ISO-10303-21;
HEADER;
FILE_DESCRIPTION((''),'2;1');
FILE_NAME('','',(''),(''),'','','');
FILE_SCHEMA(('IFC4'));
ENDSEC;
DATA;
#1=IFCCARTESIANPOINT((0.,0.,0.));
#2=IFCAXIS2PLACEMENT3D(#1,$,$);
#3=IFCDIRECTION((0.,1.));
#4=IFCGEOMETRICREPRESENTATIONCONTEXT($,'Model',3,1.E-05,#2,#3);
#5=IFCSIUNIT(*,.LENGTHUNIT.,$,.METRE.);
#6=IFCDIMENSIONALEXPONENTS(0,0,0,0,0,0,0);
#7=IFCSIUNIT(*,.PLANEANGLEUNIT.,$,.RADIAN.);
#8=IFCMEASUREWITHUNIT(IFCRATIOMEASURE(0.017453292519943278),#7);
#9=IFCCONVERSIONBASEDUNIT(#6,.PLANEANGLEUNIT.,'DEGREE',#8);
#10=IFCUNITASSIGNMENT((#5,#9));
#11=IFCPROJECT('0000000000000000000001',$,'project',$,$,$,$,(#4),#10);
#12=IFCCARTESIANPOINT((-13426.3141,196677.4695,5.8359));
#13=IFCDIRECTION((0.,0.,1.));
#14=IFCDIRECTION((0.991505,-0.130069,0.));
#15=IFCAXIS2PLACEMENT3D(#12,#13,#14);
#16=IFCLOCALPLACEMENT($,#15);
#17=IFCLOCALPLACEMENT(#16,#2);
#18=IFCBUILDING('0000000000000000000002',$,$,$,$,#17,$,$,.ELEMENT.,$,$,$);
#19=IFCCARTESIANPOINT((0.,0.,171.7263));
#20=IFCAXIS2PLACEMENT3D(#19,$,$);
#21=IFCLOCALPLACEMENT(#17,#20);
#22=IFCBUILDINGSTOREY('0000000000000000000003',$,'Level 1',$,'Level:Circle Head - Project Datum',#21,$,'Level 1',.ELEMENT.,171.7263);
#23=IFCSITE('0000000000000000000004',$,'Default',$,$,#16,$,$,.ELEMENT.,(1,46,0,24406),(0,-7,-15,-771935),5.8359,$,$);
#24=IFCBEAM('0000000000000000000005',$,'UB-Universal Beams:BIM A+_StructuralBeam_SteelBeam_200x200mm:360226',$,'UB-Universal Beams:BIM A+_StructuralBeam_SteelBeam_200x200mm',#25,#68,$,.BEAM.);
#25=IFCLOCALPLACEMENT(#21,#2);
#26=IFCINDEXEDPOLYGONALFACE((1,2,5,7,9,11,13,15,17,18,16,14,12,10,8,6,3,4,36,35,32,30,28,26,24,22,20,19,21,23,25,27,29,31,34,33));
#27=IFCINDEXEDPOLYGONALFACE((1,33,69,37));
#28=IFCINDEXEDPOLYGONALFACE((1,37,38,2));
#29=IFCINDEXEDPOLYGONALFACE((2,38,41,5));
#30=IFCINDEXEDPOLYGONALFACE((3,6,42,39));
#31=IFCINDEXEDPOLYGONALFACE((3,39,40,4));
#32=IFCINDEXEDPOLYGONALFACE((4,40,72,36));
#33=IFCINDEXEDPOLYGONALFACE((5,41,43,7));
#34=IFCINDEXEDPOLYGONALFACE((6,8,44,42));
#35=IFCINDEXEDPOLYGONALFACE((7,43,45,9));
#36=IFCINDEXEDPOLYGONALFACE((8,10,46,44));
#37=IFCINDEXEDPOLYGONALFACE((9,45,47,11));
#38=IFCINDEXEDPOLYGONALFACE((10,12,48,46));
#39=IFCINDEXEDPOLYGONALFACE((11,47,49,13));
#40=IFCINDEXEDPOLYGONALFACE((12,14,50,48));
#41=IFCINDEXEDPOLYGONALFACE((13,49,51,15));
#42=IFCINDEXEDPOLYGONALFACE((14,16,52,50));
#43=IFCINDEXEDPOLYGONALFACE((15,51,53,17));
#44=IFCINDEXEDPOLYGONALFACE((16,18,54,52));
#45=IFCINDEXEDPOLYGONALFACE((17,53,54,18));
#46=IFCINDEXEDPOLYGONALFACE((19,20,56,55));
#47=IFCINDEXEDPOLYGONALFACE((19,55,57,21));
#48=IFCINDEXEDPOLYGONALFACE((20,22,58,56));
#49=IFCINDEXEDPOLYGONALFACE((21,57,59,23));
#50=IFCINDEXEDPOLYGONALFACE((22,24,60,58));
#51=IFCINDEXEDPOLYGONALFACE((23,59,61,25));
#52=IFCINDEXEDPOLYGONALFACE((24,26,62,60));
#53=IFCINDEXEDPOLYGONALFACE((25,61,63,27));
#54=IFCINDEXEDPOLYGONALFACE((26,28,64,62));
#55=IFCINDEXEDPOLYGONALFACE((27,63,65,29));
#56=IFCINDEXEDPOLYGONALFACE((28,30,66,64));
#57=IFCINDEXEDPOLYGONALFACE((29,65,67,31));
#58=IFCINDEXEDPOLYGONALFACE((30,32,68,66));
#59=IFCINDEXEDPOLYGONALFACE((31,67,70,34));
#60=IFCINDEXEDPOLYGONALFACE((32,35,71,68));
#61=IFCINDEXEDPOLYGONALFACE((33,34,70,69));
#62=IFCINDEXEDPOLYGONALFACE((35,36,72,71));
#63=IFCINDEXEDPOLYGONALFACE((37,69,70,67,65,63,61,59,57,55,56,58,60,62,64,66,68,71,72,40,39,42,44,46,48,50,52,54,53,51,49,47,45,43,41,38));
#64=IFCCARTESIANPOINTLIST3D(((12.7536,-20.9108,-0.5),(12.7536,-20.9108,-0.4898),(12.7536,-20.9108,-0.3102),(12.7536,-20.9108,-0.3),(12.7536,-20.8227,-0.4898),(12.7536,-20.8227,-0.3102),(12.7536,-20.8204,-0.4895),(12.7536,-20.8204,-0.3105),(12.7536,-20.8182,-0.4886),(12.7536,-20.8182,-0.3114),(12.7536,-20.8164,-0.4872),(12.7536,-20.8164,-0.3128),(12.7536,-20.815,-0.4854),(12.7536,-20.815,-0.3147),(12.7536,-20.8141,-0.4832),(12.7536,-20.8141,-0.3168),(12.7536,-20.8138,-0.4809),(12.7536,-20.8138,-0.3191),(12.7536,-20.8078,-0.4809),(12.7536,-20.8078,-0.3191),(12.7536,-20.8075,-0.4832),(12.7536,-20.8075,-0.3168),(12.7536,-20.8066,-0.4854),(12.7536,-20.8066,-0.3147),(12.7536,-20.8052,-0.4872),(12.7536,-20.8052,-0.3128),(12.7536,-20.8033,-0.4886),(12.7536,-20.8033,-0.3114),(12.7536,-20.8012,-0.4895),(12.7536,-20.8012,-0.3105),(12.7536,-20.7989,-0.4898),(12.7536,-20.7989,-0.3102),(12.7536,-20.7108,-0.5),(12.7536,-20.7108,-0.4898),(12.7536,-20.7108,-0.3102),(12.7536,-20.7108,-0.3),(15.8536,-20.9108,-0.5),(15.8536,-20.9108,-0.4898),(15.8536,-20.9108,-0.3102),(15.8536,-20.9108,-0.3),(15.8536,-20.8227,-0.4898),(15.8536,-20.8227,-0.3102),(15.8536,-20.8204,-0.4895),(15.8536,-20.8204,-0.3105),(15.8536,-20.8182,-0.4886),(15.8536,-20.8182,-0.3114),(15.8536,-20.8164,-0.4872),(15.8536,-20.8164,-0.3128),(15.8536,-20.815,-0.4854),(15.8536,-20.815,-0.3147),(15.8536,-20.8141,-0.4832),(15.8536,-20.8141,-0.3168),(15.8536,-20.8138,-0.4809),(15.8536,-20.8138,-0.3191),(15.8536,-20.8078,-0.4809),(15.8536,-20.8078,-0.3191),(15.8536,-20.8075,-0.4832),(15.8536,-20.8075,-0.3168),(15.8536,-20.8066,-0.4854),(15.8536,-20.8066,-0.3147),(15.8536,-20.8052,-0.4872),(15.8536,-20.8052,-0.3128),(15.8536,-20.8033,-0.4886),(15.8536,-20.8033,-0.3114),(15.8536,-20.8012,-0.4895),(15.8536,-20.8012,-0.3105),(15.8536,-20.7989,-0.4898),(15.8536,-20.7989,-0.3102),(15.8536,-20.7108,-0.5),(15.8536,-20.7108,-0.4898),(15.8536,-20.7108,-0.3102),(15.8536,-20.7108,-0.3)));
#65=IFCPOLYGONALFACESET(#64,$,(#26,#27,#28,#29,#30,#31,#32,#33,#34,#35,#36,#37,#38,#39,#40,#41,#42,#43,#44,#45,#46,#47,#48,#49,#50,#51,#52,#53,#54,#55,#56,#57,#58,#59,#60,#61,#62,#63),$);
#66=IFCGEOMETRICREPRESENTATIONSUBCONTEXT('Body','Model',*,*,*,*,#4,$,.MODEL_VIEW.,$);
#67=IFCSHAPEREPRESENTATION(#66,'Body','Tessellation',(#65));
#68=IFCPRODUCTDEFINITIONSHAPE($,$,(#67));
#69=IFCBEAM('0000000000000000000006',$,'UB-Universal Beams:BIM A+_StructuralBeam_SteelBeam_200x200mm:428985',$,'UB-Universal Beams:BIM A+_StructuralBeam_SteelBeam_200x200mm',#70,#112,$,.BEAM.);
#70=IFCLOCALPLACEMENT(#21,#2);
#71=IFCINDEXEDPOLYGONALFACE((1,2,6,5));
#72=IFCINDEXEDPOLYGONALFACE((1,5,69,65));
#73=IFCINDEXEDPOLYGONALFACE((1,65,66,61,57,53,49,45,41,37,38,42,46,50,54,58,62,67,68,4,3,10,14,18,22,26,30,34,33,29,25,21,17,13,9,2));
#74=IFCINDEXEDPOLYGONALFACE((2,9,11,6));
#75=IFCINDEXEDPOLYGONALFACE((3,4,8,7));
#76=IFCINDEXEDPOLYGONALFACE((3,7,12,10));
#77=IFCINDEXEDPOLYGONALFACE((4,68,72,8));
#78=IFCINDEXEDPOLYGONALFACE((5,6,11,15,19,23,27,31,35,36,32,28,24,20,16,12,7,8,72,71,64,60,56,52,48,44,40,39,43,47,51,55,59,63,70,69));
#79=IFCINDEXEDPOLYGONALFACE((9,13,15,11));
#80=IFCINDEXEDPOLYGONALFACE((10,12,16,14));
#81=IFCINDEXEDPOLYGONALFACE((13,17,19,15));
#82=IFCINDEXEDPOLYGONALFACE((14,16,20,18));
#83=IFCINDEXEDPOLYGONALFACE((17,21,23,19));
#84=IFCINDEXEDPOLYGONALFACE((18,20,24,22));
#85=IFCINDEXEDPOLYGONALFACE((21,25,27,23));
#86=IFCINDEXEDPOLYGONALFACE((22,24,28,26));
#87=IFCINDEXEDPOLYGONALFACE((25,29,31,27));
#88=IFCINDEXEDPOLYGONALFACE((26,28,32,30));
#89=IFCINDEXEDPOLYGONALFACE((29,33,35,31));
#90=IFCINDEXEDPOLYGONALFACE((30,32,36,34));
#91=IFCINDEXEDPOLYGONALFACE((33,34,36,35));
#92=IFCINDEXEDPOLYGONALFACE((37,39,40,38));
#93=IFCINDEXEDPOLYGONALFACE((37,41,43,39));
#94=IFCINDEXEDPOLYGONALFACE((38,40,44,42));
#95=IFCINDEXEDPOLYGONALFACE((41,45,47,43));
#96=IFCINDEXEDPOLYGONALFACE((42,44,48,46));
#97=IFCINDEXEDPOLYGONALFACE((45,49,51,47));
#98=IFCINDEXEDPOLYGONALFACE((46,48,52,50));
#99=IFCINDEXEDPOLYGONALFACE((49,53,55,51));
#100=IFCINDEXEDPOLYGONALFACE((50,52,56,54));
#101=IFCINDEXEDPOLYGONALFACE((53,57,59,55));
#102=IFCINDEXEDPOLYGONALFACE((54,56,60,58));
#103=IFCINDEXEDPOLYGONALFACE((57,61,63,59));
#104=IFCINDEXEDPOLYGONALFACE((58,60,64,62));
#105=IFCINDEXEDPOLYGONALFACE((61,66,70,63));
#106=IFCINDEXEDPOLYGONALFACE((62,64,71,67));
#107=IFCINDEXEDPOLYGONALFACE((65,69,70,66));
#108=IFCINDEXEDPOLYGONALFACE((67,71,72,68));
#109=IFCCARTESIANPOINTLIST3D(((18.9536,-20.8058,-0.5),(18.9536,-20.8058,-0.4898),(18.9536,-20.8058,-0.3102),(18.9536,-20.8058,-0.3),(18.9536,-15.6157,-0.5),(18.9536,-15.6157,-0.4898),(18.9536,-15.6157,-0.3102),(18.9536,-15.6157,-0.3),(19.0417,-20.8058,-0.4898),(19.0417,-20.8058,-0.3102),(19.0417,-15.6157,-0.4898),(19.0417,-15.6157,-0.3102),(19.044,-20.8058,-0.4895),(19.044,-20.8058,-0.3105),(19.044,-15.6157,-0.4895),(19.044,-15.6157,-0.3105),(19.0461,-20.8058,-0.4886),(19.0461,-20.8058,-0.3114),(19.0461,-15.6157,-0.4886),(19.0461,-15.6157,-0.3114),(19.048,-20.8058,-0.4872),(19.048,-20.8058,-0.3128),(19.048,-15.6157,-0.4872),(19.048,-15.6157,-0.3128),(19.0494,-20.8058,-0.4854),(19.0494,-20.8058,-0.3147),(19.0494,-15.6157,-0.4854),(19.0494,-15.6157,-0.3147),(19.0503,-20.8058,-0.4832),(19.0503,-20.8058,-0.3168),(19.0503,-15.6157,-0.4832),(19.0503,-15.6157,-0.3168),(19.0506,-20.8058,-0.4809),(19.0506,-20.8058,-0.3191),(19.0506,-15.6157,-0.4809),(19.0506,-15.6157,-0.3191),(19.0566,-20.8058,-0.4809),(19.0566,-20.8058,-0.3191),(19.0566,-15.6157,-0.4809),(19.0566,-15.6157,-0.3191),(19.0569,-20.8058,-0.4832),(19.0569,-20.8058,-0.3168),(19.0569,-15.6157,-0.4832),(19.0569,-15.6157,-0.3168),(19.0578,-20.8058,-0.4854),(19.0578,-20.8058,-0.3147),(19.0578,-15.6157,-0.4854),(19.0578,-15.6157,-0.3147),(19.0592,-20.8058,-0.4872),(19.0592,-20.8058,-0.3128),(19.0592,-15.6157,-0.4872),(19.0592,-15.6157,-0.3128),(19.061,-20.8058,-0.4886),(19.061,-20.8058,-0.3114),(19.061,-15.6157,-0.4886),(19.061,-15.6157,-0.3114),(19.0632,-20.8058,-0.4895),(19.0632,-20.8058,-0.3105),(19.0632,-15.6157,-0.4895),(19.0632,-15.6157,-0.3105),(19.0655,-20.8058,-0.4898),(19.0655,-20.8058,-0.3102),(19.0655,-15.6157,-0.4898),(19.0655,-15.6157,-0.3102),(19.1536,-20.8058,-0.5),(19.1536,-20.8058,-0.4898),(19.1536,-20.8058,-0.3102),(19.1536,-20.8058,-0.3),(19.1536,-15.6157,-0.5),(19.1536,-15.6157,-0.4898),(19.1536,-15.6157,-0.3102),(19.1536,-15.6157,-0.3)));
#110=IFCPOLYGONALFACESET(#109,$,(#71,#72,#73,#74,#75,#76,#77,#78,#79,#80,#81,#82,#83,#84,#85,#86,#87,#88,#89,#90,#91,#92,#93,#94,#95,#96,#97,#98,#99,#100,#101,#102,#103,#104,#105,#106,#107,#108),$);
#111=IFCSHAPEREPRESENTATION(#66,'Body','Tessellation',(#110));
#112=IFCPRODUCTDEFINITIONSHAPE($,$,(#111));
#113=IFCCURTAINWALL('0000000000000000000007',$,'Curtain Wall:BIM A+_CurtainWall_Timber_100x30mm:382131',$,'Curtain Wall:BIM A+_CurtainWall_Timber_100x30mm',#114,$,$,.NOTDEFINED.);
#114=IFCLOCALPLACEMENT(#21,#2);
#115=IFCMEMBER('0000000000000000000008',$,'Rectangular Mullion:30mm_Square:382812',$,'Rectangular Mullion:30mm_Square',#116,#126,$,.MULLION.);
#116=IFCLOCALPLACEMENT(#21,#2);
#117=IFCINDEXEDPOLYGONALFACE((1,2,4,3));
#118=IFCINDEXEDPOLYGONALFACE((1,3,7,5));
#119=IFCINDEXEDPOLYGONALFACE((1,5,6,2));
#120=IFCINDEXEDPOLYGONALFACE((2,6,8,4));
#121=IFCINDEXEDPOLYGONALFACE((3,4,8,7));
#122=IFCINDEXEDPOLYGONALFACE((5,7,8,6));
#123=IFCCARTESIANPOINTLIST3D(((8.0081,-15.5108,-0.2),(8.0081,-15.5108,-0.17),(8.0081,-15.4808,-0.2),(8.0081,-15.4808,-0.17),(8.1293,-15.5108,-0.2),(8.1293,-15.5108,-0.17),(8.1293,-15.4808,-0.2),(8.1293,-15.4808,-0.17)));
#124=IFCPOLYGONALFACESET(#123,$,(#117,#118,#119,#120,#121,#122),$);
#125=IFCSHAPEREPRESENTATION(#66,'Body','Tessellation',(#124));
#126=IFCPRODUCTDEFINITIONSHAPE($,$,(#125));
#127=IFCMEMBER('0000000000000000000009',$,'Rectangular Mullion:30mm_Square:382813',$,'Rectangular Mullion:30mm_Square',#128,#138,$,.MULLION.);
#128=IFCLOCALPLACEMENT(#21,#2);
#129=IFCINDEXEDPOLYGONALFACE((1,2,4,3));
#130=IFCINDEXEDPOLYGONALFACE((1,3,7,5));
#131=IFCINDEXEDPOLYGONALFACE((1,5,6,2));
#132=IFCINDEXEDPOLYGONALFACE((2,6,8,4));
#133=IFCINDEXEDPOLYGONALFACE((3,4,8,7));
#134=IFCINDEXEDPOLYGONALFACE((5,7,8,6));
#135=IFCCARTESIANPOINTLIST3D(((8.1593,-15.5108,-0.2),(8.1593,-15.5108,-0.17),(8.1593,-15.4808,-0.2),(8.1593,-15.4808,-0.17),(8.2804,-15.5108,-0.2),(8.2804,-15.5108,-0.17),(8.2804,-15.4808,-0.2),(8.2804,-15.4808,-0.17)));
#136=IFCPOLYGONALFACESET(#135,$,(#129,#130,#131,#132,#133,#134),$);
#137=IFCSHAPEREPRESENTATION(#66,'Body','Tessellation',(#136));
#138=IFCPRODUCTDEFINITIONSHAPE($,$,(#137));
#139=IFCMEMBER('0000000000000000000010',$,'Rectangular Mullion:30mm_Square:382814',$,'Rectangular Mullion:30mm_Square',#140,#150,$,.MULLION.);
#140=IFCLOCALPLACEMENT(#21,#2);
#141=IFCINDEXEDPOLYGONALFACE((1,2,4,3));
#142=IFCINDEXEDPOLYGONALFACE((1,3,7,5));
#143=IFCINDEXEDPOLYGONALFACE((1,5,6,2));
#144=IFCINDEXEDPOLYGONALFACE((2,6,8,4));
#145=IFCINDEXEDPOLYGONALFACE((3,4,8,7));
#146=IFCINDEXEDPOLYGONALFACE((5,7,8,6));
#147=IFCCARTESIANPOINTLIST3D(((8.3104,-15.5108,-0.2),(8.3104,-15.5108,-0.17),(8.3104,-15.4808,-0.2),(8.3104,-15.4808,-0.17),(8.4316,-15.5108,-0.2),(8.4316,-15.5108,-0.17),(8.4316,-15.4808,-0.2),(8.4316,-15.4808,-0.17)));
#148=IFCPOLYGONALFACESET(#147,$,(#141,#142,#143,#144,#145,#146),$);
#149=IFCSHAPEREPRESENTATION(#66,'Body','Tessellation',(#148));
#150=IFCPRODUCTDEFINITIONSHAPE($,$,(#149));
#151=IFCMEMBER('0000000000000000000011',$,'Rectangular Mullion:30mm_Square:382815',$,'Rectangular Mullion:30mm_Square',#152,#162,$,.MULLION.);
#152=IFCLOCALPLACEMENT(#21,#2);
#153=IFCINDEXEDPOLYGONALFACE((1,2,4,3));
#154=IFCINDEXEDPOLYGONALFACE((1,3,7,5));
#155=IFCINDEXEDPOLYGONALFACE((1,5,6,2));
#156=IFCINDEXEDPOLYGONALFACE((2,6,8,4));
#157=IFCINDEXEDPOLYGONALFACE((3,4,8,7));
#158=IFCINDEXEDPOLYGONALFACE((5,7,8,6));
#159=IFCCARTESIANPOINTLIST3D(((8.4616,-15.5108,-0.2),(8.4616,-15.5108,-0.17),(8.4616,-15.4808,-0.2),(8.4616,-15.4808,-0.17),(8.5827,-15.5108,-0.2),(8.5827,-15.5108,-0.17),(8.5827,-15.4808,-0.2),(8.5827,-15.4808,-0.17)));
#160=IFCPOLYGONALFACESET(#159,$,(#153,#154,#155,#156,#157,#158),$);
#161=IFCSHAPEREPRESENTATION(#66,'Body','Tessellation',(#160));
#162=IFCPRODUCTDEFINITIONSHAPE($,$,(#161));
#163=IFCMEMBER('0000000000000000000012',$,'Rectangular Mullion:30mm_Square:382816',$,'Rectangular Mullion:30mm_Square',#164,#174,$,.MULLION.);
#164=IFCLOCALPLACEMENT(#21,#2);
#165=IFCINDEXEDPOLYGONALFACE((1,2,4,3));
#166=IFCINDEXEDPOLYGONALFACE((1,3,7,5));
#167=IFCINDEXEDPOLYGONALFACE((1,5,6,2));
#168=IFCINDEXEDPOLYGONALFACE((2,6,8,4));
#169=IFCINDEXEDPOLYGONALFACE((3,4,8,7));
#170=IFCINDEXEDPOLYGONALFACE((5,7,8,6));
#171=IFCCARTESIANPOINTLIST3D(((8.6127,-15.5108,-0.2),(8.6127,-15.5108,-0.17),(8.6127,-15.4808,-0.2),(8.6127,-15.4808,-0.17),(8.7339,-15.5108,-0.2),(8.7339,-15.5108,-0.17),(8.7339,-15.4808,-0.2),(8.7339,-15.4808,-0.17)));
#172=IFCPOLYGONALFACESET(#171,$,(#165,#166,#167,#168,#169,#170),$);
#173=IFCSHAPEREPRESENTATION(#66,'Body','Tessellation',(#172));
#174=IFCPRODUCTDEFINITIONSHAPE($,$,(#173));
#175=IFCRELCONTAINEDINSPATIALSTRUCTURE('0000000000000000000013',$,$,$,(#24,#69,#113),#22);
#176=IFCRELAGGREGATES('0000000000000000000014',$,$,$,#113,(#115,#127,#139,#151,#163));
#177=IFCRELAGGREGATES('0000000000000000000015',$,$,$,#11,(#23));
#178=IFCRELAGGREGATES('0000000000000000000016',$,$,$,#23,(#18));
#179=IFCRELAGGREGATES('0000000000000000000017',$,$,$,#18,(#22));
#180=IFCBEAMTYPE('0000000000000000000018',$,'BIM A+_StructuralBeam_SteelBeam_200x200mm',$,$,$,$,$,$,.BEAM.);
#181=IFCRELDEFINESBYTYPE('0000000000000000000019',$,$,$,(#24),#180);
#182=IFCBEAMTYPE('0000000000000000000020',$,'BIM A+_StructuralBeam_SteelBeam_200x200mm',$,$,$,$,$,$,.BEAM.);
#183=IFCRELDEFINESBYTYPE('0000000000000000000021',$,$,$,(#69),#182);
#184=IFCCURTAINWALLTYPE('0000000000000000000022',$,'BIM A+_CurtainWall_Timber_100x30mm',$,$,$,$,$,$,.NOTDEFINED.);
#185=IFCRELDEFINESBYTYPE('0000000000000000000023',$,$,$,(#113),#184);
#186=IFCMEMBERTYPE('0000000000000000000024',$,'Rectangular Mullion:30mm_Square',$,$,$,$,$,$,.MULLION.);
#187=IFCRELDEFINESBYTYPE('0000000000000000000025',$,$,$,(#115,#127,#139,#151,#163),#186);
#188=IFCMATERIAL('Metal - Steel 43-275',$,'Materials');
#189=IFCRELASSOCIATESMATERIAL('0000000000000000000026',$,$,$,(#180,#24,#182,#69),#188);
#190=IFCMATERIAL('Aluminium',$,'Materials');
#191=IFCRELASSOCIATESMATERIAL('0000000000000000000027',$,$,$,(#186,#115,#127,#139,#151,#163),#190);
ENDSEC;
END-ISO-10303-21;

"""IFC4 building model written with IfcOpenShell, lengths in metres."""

from ifc_helpers import new_model, entity, si_unit, converted_unit, direction, frame, origin, place, context, subcontext, project, spatial, line, arc, indexed_curve, outline, extrude, source, transform, mapped, material, type_object, type_shapes, element, aggregate, save


model = new_model("IFC4")

# Units and contexts
model_context = context("Model", 3, precision=1e-05, world=origin(), true_north=direction((0.0, 1.0)))
body_context = subcontext(model_context, "Body", "Model", "MODEL_VIEW")
ifc_project = project(units=[si_unit("LENGTHUNIT", "METRE"), converted_unit("PLANEANGLEUNIT", "DEGREE", entity("IfcRatioMeasure", 0.017453292519943278), si_unit("PLANEANGLEUNIT", "RADIAN"), dimensions=[0, 0, 0, 0, 0, 0, 0])], contexts=[model_context])

# Site, building, storey
site_placement = place(None, frame((-13426.3141, 196677.4695, 5.8359), z_axis=(0.0, 0.0, 1.0), x_axis=(0.991505, -0.130069, 0.0)))
site = spatial("IfcSite", under=ifc_project, at=site_placement, Name="Default", CompositionType="ELEMENT", RefLatitude=(1, 46, 0, 24406), RefLongitude=(0, -7, -15, -771935), RefElevation=5.8359)
building_placement = place(site_placement, origin())
building = spatial("IfcBuilding", under=site, at=building_placement, CompositionType="ELEMENT")
storey_placement = place(building_placement, frame((0.0, 0.0, 171.7263)))
storey = spatial("IfcBuildingStorey", under=building, at=storey_placement, Name="Level 1", ObjectType="Level:Circle Head - Project Datum", LongName="Level 1", CompositionType="ELEMENT", Elevation=171.7263)

# Beams
ifc_material_1 = material(Name="Metal - Steel 43-275", Category="Materials")
beam_type_1 = type_object("IfcBeamType", Name="BIM A+_StructuralBeam_SteelBeam_200x200mm", PredefinedType="BEAM", material=ifc_material_1)
shared_shape_1 = source(origin(), body_context, "Body", "SweptSolid", [
    extrude(outline(indexed_curve([(-0.1, -0.1), (-0.0898, -0.1), (-0.0898, -0.0119), (-0.0872, -0.0056), (-0.0809, -0.003), (0.0809, -0.003), (0.0872, -0.0056), (0.0898, -0.0119), (0.0898, -0.1), (0.1, -0.1), (0.1, 0.1), (0.0898, 0.1), (0.0898, 0.0119), (0.0872, 0.0056), (0.0809, 0.003), (-0.0809, 0.003), (-0.0872, 0.0056), (-0.0898, 0.0119), (-0.0898, 0.1), (-0.1, 0.1)], segments=[line(1, 2, 3), arc(3, 4, 5), line(5, 6), arc(6, 7, 8), line(8, 9, 10, 11, 12, 13), arc(13, 14, 15), line(15, 16), arc(16, 17, 18), line(18, 19, 20, 1)], self_intersect=False)), frame((-0.3639, 0.0, 0.0), z_axis=(1.0, 0.0, 0.0), x_axis=(0.0, 0.0, -1.0)), (0.0, 0.0, 1.0), 3.1),
])
type_shapes(beam_type_1, [shared_shape_1])
for number, where, z_axis, x_axis, name in (
    (1, (15.4897, -20.8108, -0.4), (0.0, 0.0, 1.0), (-1.0, 0.0, 0.0), "UB-Universal Beams:BIM A+_StructuralBeam_SteelBeam_200x200mm:360226"),
):
    element("IfcBeam", number, at=place(storey_placement, frame(where, z_axis=z_axis, x_axis=x_axis)), inside=storey, type_object=beam_type_1, material=ifc_material_1, Name=name, ObjectType="UB-Universal Beams:BIM A+_StructuralBeam_SteelBeam_200x200mm", PredefinedType="BEAM", context=body_context, shape_type="MappedRepresentation", body=[
        mapped(shared_shape_1, transform((0.0, 0.0, 0.0), scale=1.0)),
    ])
beam_type_2 = type_object("IfcBeamType", Name="BIM A+_StructuralBeam_SteelBeam_200x200mm", PredefinedType="BEAM", material=ifc_material_1)
shared_shape_2 = source(origin(), body_context, "Body", "SweptSolid", [
    extrude(outline(indexed_curve([(-0.1, -0.1), (-0.0898, -0.1), (-0.0898, -0.0119), (-0.0872, -0.0056), (-0.0809, -0.003), (0.0809, -0.003), (0.0872, -0.0056), (0.0898, -0.0119), (0.0898, -0.1), (0.1, -0.1), (0.1, 0.1), (0.0898, 0.1), (0.0898, 0.0119), (0.0872, 0.0056), (0.0809, 0.003), (-0.0809, 0.003), (-0.0872, 0.0056), (-0.0898, 0.0119), (-0.0898, 0.1), (-0.1, 0.1)], segments=[line(1, 2, 3), arc(3, 4, 5), line(5, 6), arc(6, 7, 8), line(8, 9, 10, 11, 12, 13), arc(13, 14, 15), line(15, 16), arc(16, 17, 18), line(18, 19, 20, 1)], self_intersect=False)), frame((-2.4951, 0.0, 0.0), z_axis=(1.0, 0.0, 0.0), x_axis=(0.0, 0.0, -1.0)), (0.0, 0.0, 1.0), 5.1901),
])
type_shapes(beam_type_2, [shared_shape_2])
beam_1_placement = place(storey_placement, frame((19.0536, -18.1108, -0.4), z_axis=(0.0, 0.0, 1.0), x_axis=(0.0, -1.0, 0.0)))
element("IfcBeam", 2, at=beam_1_placement, inside=storey, type_object=beam_type_2, material=ifc_material_1, Name="UB-Universal Beams:BIM A+_StructuralBeam_SteelBeam_200x200mm:428985", ObjectType="UB-Universal Beams:BIM A+_StructuralBeam_SteelBeam_200x200mm", PredefinedType="BEAM", context=body_context, shape_type="MappedRepresentation", body=[
    mapped(shared_shape_2, transform((0.0, 0.0, 0.0), scale=1.0)),
])

# Curtain wall, members
curtain_wall_type = type_object("IfcCurtainWallType", Name="BIM A+_CurtainWall_Timber_100x30mm", PredefinedType="NOTDEFINED")
curtain_wall_placement = place(storey_placement, frame((0.0, 0.0, -171.7263)))
curtain_wall = element("IfcCurtainWall", 3, at=curtain_wall_placement, inside=storey, type_object=curtain_wall_type, Name="Curtain Wall:BIM A+_CurtainWall_Timber_100x30mm:382131", ObjectType="Curtain Wall:BIM A+_CurtainWall_Timber_100x30mm", PredefinedType="NOTDEFINED")
ifc_material_2 = material(Name="Aluminium", Category="Materials")
member_type = type_object("IfcMemberType", Name="Rectangular Mullion:30mm_Square", PredefinedType="MULLION", material=ifc_material_2)
shared_shape_3 = source(origin(), body_context, "Body", "SweptSolid", [
    extrude(outline(indexed_curve([(-0.015, -0.015), (0.015, -0.015), (0.015, 0.015), (-0.015, 0.015), (-0.015, -0.015)], self_intersect=False)), frame((-0.015, 0.0, -0.1212), z_axis=(0.0, 0.0, 1.0), x_axis=(0.0, -1.0, 0.0)), (0.0, 0.0, 1.0), 0.1212),
])
type_shapes(member_type, [shared_shape_3])
member_1_placement = place(curtain_wall_placement, frame((8.0081, -15.4958, 171.5263), z_axis=(-1.0, 0.0, 0.0), x_axis=(0.0, 0.0, -1.0)))
member_1 = element("IfcMember", 4, at=member_1_placement, type_object=member_type, material=ifc_material_2, Name="Rectangular Mullion:30mm_Square:382812", ObjectType="Rectangular Mullion:30mm_Square", PredefinedType="MULLION", context=body_context, shape_type="MappedRepresentation", body=[
    mapped(shared_shape_3, transform((0.0, 0.0, 0.0), scale=1.0)),
])
member_2_placement = place(curtain_wall_placement, frame((8.1593, -15.4958, 171.5263), z_axis=(-1.0, 0.0, 0.0), x_axis=(0.0, 0.0, -1.0)))
member_2 = element("IfcMember", 5, at=member_2_placement, type_object=member_type, material=ifc_material_2, Name="Rectangular Mullion:30mm_Square:382813", ObjectType="Rectangular Mullion:30mm_Square", PredefinedType="MULLION", context=body_context, shape_type="MappedRepresentation", body=[
    mapped(shared_shape_3, transform((0.0, 0.0, 0.0), scale=1.0)),
])
member_3_placement = place(curtain_wall_placement, frame((8.3104, -15.4958, 171.5263), z_axis=(-1.0, 0.0, 0.0), x_axis=(0.0, 0.0, -1.0)))
member_3 = element("IfcMember", 6, at=member_3_placement, type_object=member_type, material=ifc_material_2, Name="Rectangular Mullion:30mm_Square:382814", ObjectType="Rectangular Mullion:30mm_Square", PredefinedType="MULLION", context=body_context, shape_type="MappedRepresentation", body=[
    mapped(shared_shape_3, transform((0.0, 0.0, 0.0), scale=1.0)),
])
member_4_placement = place(curtain_wall_placement, frame((8.4616, -15.4958, 171.5263), z_axis=(-1.0, 0.0, 0.0), x_axis=(0.0, 0.0, -1.0)))
member_4 = element("IfcMember", 7, at=member_4_placement, type_object=member_type, material=ifc_material_2, Name="Rectangular Mullion:30mm_Square:382815", ObjectType="Rectangular Mullion:30mm_Square", PredefinedType="MULLION", context=body_context, shape_type="MappedRepresentation", body=[
    mapped(shared_shape_3, transform((0.0, 0.0, 0.0), scale=1.0)),
])
member_5_placement = place(curtain_wall_placement, frame((8.6127, -15.4958, 171.5263), z_axis=(-1.0, 0.0, 0.0), x_axis=(0.0, 0.0, -1.0)))
member_5 = element("IfcMember", 8, at=member_5_placement, type_object=member_type, material=ifc_material_2, Name="Rectangular Mullion:30mm_Square:382816", ObjectType="Rectangular Mullion:30mm_Square", PredefinedType="MULLION", context=body_context, shape_type="MappedRepresentation", body=[
    mapped(shared_shape_3, transform((0.0, 0.0, 0.0), scale=1.0)),
])
aggregate(curtain_wall, [member_1, member_2, member_3, member_4, member_5])

save(model, "model.ifc")
